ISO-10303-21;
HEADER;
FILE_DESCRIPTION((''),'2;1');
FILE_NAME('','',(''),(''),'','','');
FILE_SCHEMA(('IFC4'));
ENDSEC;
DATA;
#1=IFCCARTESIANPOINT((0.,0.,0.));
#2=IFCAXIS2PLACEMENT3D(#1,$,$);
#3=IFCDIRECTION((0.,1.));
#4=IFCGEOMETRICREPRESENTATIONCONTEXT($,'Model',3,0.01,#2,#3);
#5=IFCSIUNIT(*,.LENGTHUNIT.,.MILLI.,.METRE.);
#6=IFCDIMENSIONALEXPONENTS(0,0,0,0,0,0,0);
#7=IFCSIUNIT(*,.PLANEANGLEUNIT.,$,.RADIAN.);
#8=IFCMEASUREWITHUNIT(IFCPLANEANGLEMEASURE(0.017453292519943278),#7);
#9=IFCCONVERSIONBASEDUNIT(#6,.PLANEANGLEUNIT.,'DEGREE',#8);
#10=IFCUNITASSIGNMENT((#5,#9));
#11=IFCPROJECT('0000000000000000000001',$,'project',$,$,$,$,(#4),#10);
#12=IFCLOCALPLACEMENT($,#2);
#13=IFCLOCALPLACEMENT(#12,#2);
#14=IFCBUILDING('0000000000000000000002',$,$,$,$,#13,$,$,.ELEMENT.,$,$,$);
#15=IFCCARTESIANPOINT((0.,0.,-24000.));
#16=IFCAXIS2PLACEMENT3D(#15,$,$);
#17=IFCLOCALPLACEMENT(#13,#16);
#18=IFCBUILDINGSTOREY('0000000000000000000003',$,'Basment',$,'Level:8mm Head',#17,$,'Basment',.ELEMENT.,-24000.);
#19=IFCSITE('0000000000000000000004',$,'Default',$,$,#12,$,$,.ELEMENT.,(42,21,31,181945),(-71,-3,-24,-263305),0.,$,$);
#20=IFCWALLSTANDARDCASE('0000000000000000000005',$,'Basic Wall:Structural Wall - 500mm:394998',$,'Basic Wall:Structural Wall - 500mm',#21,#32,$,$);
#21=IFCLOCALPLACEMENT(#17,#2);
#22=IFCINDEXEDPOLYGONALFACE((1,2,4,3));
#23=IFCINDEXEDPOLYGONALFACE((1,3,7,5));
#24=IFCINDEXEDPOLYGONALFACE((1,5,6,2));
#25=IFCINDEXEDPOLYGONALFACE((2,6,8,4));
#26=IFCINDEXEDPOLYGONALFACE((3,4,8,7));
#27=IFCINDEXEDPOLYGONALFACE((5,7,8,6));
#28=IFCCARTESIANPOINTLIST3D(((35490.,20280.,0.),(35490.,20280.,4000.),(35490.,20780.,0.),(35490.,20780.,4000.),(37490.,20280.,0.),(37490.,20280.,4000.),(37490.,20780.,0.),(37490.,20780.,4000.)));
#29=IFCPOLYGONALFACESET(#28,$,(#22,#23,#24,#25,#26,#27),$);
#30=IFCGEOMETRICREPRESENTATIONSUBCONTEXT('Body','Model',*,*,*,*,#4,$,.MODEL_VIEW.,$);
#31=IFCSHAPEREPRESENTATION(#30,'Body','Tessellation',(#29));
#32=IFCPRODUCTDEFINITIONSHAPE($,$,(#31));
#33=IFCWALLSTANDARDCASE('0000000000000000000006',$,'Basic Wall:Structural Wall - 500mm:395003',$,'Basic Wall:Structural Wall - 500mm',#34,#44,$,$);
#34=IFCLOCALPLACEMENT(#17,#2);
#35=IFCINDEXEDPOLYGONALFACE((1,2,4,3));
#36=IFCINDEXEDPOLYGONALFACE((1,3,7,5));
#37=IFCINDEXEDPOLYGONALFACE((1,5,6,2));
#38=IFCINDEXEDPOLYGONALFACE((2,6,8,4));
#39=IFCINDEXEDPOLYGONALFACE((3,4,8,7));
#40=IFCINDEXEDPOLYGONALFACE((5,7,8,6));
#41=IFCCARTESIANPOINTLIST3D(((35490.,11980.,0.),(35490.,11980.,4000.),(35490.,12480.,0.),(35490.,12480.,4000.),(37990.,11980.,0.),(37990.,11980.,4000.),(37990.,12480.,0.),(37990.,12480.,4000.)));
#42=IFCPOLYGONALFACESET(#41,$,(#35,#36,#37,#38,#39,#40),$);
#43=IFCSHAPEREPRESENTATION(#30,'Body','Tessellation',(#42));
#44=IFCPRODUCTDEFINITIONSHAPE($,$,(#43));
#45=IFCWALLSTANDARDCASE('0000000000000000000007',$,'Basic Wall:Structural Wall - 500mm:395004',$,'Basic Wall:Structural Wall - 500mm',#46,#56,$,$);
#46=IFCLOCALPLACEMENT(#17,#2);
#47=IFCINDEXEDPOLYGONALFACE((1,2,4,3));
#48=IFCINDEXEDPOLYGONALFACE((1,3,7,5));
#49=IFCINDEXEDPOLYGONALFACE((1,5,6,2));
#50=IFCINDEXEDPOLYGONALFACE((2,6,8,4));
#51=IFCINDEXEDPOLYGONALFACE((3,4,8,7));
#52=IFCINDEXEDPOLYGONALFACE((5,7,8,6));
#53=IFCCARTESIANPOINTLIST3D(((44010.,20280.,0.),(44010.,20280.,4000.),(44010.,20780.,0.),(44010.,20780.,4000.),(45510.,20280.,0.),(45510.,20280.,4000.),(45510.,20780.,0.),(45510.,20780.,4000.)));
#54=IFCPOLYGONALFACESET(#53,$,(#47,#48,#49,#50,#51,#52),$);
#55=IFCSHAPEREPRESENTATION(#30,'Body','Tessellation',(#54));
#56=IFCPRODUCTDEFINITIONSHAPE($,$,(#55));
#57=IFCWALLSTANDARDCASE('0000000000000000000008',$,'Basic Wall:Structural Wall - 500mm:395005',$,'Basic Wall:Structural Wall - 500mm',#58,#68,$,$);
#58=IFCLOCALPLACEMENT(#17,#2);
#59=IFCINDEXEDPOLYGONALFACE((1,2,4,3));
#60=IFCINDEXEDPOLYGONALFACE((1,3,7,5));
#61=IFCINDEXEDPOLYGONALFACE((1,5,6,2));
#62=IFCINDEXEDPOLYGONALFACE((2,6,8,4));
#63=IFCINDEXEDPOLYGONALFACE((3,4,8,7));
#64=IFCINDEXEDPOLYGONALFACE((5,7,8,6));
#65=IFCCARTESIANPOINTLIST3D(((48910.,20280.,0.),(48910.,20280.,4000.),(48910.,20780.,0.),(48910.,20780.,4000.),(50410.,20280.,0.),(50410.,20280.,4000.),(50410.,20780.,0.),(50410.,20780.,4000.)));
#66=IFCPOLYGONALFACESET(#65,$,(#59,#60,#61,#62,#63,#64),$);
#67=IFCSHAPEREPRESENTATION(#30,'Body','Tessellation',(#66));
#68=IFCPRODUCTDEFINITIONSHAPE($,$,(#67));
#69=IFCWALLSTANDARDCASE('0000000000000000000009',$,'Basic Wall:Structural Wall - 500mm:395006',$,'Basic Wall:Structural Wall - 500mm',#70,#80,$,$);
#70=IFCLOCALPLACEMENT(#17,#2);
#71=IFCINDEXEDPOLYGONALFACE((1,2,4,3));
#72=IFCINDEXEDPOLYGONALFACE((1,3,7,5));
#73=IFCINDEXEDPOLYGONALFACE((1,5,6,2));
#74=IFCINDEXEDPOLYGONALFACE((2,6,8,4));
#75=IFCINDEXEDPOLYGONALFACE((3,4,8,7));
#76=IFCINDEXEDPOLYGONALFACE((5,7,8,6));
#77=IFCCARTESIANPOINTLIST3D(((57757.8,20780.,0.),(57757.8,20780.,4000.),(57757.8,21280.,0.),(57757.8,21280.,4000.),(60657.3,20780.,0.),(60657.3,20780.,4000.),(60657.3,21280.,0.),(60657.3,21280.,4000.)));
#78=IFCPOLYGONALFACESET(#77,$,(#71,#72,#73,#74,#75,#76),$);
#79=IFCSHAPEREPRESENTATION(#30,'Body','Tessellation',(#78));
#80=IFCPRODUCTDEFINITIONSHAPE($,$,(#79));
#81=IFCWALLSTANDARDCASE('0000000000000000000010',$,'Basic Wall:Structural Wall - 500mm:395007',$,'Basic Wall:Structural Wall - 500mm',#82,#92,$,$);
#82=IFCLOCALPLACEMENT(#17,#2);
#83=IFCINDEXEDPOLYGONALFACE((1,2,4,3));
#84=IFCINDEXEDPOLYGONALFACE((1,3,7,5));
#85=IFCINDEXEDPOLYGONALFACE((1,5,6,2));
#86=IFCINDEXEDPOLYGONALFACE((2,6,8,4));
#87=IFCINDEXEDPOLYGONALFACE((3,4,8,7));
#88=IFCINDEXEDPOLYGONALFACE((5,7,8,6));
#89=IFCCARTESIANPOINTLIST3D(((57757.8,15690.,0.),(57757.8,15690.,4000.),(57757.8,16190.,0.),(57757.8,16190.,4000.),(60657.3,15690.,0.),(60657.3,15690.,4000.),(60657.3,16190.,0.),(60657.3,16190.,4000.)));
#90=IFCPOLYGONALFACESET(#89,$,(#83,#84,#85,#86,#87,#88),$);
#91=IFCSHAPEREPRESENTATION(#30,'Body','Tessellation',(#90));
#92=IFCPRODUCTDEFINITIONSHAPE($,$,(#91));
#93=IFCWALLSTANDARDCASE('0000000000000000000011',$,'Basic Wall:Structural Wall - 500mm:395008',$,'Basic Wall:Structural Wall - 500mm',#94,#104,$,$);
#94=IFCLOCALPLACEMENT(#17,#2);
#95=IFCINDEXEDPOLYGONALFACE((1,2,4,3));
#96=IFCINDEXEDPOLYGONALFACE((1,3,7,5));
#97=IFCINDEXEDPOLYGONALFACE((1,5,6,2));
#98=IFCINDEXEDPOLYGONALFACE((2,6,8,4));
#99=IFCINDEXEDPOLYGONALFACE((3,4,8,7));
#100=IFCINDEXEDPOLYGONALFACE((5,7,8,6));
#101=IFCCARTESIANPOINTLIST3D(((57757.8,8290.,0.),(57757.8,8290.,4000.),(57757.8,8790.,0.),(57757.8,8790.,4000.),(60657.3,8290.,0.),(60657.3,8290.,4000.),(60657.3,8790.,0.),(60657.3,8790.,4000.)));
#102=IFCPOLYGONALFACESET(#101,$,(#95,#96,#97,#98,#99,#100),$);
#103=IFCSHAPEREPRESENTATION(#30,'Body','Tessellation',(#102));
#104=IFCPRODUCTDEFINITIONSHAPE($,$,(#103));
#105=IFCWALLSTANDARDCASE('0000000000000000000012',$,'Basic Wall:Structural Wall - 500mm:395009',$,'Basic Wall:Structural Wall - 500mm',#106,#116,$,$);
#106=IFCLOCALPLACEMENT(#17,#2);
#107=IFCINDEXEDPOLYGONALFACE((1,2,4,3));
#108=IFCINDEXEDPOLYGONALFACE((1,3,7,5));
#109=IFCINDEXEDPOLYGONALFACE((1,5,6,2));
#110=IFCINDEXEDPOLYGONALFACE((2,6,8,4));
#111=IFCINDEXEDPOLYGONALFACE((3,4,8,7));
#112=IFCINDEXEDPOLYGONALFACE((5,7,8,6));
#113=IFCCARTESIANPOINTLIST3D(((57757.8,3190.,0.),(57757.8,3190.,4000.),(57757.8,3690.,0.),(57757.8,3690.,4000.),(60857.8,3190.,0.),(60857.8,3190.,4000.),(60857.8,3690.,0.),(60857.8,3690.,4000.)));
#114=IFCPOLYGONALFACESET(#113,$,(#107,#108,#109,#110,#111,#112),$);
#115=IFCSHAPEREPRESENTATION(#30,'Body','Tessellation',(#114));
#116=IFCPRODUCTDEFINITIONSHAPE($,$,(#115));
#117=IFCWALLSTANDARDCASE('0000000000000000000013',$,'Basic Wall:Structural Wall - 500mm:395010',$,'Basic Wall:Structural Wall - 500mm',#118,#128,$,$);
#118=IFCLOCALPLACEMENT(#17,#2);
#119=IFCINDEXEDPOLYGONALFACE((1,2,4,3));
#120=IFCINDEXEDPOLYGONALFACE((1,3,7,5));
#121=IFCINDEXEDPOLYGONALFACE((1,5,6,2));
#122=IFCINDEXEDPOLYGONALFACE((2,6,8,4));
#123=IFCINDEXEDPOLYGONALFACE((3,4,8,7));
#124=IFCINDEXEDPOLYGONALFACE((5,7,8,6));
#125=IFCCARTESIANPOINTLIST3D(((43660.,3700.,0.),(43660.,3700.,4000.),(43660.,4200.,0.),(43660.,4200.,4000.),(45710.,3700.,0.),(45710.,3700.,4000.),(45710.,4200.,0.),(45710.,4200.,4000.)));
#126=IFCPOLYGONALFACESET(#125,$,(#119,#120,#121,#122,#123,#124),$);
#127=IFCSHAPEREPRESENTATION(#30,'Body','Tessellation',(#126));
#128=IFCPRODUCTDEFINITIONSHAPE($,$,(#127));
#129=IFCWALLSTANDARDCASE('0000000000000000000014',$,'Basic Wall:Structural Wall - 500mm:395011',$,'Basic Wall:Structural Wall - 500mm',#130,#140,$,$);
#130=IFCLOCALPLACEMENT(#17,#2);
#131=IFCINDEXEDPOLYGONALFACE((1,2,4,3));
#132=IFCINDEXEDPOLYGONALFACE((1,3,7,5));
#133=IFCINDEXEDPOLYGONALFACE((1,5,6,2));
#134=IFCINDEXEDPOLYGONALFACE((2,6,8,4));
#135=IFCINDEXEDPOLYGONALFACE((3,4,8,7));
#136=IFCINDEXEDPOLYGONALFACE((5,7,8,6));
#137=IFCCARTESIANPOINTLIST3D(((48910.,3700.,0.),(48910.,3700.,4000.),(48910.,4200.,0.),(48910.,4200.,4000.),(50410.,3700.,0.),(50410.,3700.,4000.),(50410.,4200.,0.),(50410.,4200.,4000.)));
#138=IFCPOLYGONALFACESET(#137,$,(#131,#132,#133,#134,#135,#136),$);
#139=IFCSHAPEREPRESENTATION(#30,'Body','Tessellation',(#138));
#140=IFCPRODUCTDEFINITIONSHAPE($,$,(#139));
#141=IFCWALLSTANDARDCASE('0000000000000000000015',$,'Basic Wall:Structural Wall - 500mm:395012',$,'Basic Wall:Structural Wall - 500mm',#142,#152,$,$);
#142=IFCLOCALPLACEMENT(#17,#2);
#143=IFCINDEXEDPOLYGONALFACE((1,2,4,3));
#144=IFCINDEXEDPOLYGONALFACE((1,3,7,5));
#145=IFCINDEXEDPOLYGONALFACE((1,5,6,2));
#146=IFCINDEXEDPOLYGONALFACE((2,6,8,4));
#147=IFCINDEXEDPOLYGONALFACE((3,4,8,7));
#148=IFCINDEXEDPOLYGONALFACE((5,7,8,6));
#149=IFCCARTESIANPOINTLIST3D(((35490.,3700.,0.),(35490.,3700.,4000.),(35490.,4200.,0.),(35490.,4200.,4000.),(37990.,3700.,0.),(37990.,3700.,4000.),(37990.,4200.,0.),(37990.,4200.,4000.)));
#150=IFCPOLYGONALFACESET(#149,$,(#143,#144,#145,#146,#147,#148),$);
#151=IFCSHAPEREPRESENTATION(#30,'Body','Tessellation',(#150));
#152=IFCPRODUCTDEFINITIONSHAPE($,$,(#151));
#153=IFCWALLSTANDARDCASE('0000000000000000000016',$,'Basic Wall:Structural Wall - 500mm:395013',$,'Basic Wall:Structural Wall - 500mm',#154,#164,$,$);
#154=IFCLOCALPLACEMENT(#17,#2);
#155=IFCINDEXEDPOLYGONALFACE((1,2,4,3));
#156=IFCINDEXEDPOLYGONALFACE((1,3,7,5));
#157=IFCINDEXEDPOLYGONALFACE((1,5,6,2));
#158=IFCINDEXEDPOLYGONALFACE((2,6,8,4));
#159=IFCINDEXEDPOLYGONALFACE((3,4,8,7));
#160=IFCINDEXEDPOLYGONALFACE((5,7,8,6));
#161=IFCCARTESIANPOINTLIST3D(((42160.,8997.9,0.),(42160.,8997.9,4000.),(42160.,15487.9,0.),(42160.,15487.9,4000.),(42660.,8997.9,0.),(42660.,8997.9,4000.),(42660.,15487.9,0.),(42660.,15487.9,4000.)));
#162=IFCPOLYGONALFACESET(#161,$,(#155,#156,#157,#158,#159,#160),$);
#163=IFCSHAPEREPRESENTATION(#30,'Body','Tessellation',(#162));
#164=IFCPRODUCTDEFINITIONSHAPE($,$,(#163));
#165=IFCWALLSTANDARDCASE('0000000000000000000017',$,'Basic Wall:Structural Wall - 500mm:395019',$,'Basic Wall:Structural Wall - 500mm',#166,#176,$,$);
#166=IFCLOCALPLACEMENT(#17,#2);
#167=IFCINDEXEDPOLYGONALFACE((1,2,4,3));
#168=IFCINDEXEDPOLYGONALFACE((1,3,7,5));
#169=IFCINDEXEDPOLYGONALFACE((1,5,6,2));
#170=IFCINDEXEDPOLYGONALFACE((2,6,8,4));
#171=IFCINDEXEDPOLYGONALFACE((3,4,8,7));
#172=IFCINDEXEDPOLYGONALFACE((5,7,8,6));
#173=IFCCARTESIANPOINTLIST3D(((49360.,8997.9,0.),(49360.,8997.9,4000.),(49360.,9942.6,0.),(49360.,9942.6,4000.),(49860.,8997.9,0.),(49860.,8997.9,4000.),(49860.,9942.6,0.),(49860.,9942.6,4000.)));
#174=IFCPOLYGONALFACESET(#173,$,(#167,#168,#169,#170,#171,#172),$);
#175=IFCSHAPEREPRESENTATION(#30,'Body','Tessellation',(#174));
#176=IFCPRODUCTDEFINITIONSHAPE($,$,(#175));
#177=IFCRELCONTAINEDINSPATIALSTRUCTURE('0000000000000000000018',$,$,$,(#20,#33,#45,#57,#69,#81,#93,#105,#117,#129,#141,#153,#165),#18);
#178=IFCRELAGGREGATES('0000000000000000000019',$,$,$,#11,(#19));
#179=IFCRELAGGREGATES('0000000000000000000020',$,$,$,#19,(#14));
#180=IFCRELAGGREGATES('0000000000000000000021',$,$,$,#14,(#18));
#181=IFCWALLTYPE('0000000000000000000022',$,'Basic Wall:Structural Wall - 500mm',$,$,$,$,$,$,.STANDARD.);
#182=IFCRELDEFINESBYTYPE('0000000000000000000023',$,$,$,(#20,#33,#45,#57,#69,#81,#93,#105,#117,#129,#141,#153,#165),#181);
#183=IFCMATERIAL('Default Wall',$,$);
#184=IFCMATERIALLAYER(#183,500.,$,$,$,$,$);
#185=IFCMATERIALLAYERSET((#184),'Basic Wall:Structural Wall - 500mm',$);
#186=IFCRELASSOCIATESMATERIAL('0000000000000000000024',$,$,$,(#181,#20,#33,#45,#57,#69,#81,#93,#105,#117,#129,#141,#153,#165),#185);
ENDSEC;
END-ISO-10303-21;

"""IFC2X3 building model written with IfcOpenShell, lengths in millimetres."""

from ifc_helpers import new_model, entity, si_unit, converted_unit, direction, frame, frame_2d, origin, place, context, subcontext, project, spatial, rectangle, extrude, material, layer, layer_set, layer_usage, type_object, element, save


model = new_model("IFC2X3")

# Units and contexts
model_context = context("Model", 3, precision=0.01, world=origin(), true_north=direction((0.0, 1.0)))
body_context = subcontext(model_context, "Body", "Model", "MODEL_VIEW")
ifc_project = project(units=[si_unit("LENGTHUNIT", "METRE", prefix="MILLI"), converted_unit("PLANEANGLEUNIT", "DEGREE", entity("IfcPlaneAngleMeasure", 0.017453292519943278), si_unit("PLANEANGLEUNIT", "RADIAN"), dimensions=[0, 0, 0, 0, 0, 0, 0])], contexts=[model_context])

# Site, building, storey
site_placement = place(None, origin())
site = spatial("IfcSite", under=ifc_project, at=site_placement, Name="Default", CompositionType="ELEMENT", RefLatitude=(42, 21, 31, 181945), RefLongitude=(-71, -3, -24, -263305), RefElevation=0.0)
building_placement = place(site_placement, origin())
building = spatial("IfcBuilding", under=site, at=building_placement, CompositionType="ELEMENT")
storey_placement = place(building_placement, frame((0.0, 0.0, -24000.0)))
storey = spatial("IfcBuildingStorey", under=building, at=storey_placement, Name="Basment", ObjectType="Level:8mm Head", LongName="Basment", CompositionType="ELEMENT", Elevation=-24000.0)

# Walls
ifc_material_1 = material(Name="Default Wall")
ifc_layer_1 = layer(ifc_material_1, 500.0)
ifc_layer_set_1 = layer_set([ifc_layer_1], Name="Basic Wall:Structural Wall - 500mm")
ifc_layer_usage_1 = layer_usage(ifc_layer_set_1, "AXIS2", "NEGATIVE", 250.0)
wall_type_1 = type_object("IfcWallType", Name="Basic Wall:Structural Wall - 500mm", PredefinedType="STANDARD", material=ifc_layer_set_1)
wall_1_placement = place(storey_placement, frame((35490.0, 20530.0, 0.0)))
element("IfcWallStandardCase", 1, at=wall_1_placement, inside=storey, type_object=wall_type_1, material=ifc_layer_usage_1, Name="Basic Wall:Structural Wall - 500mm:394998", ObjectType="Basic Wall:Structural Wall - 500mm", context=body_context, shape_type="SweptSolid", body=[
    extrude(rectangle(XDim=2000.0, YDim=500.0, at=frame_2d((1000.0, 0.0), x_axis=(-1.0, 0.0))), origin(), (0.0, 0.0, 1.0), 4000.0),
])
ifc_layer_usage_2 = layer_usage(ifc_layer_set_1, "AXIS2", "NEGATIVE", 250.0)
wall_2_placement = place(storey_placement, frame((35490.0, 12230.0, 0.0)))
element("IfcWallStandardCase", 2, at=wall_2_placement, inside=storey, type_object=wall_type_1, material=ifc_layer_usage_2, Name="Basic Wall:Structural Wall - 500mm:395003", ObjectType="Basic Wall:Structural Wall - 500mm", context=body_context, shape_type="SweptSolid", body=[
    extrude(rectangle(XDim=2500.0, YDim=500.0, at=frame_2d((1250.0, 0.0), x_axis=(-1.0, 0.0))), origin(), (0.0, 0.0, 1.0), 4000.0),
])
ifc_layer_usage_3 = layer_usage(ifc_layer_set_1, "AXIS2", "NEGATIVE", 250.0)
wall_3_placement = place(storey_placement, frame((44010.0, 20530.0, 0.0)))
element("IfcWallStandardCase", 3, at=wall_3_placement, inside=storey, type_object=wall_type_1, material=ifc_layer_usage_3, Name="Basic Wall:Structural Wall - 500mm:395004", ObjectType="Basic Wall:Structural Wall - 500mm", context=body_context, shape_type="SweptSolid", body=[
    extrude(rectangle(XDim=1500.0, YDim=500.0, at=frame_2d((750.0, 0.0), x_axis=(-1.0, 0.0))), origin(), (0.0, 0.0, 1.0), 4000.0),
])
ifc_layer_usage_4 = layer_usage(ifc_layer_set_1, "AXIS2", "NEGATIVE", 250.0)
wall_4_placement = place(storey_placement, frame((48910.0, 20530.0, 0.0)))
element("IfcWallStandardCase", 4, at=wall_4_placement, inside=storey, type_object=wall_type_1, material=ifc_layer_usage_4, Name="Basic Wall:Structural Wall - 500mm:395005", ObjectType="Basic Wall:Structural Wall - 500mm", context=body_context, shape_type="SweptSolid", body=[
    extrude(rectangle(XDim=1500.0, YDim=500.0, at=frame_2d((750.0, 0.0), x_axis=(-1.0, 0.0))), origin(), (0.0, 0.0, 1.0), 4000.0),
])
ifc_layer_usage_5 = layer_usage(ifc_layer_set_1, "AXIS2", "NEGATIVE", 250.0)
wall_5_placement = place(storey_placement, frame((57757.8, 21030.0, 0.0)))
element("IfcWallStandardCase", 5, at=wall_5_placement, inside=storey, type_object=wall_type_1, material=ifc_layer_usage_5, Name="Basic Wall:Structural Wall - 500mm:395006", ObjectType="Basic Wall:Structural Wall - 500mm", context=body_context, shape_type="SweptSolid", body=[
    extrude(rectangle(XDim=2899.5, YDim=500.0, at=frame_2d((1449.8, 0.0), x_axis=(-1.0, 0.0))), origin(), (0.0, 0.0, 1.0), 4000.0),
])
ifc_layer_usage_6 = layer_usage(ifc_layer_set_1, "AXIS2", "NEGATIVE", 250.0)
wall_6_placement = place(storey_placement, frame((57757.8, 15940.0, 0.0)))
element("IfcWallStandardCase", 6, at=wall_6_placement, inside=storey, type_object=wall_type_1, material=ifc_layer_usage_6, Name="Basic Wall:Structural Wall - 500mm:395007", ObjectType="Basic Wall:Structural Wall - 500mm", context=body_context, shape_type="SweptSolid", body=[
    extrude(rectangle(XDim=2899.5, YDim=500.0, at=frame_2d((1449.8, 0.0), x_axis=(-1.0, 0.0))), origin(), (0.0, 0.0, 1.0), 4000.0),
])
ifc_layer_usage_7 = layer_usage(ifc_layer_set_1, "AXIS2", "NEGATIVE", 250.0)
wall_7_placement = place(storey_placement, frame((57757.8, 8540.0, 0.0)))
element("IfcWallStandardCase", 7, at=wall_7_placement, inside=storey, type_object=wall_type_1, material=ifc_layer_usage_7, Name="Basic Wall:Structural Wall - 500mm:395008", ObjectType="Basic Wall:Structural Wall - 500mm", context=body_context, shape_type="SweptSolid", body=[
    extrude(rectangle(XDim=2899.5, YDim=500.0, at=frame_2d((1449.8, 0.0), x_axis=(-1.0, 0.0))), origin(), (0.0, 0.0, 1.0), 4000.0),
])
ifc_layer_usage_8 = layer_usage(ifc_layer_set_1, "AXIS2", "NEGATIVE", 250.0)
wall_8_placement = place(storey_placement, frame((57757.8, 3440.0, 0.0)))
element("IfcWallStandardCase", 8, at=wall_8_placement, inside=storey, type_object=wall_type_1, material=ifc_layer_usage_8, Name="Basic Wall:Structural Wall - 500mm:395009", ObjectType="Basic Wall:Structural Wall - 500mm", context=body_context, shape_type="SweptSolid", body=[
    extrude(rectangle(XDim=3100.0, YDim=500.0, at=frame_2d((1550.0, 0.0), x_axis=(-1.0, 0.0))), origin(), (0.0, 0.0, 1.0), 4000.0),
])
ifc_layer_usage_9 = layer_usage(ifc_layer_set_1, "AXIS2", "NEGATIVE", 250.0)
wall_9_placement = place(storey_placement, frame((43660.0, 3950.0, 0.0)))
element("IfcWallStandardCase", 9, at=wall_9_placement, inside=storey, type_object=wall_type_1, material=ifc_layer_usage_9, Name="Basic Wall:Structural Wall - 500mm:395010", ObjectType="Basic Wall:Structural Wall - 500mm", context=body_context, shape_type="SweptSolid", body=[
    extrude(rectangle(XDim=2050.0, YDim=500.0, at=frame_2d((1025.0, 0.0), x_axis=(-1.0, 0.0))), origin(), (0.0, 0.0, 1.0), 4000.0),
])
ifc_layer_usage_10 = layer_usage(ifc_layer_set_1, "AXIS2", "NEGATIVE", 250.0)
wall_10_placement = place(storey_placement, frame((48910.0, 3950.0, 0.0)))
element("IfcWallStandardCase", 10, at=wall_10_placement, inside=storey, type_object=wall_type_1, material=ifc_layer_usage_10, Name="Basic Wall:Structural Wall - 500mm:395011", ObjectType="Basic Wall:Structural Wall - 500mm", context=body_context, shape_type="SweptSolid", body=[
    extrude(rectangle(XDim=1500.0, YDim=500.0, at=frame_2d((750.0, 0.0), x_axis=(-1.0, 0.0))), origin(), (0.0, 0.0, 1.0), 4000.0),
])
ifc_layer_usage_11 = layer_usage(ifc_layer_set_1, "AXIS2", "NEGATIVE", 250.0)
wall_11_placement = place(storey_placement, frame((35490.0, 3950.0, 0.0)))
element("IfcWallStandardCase", 11, at=wall_11_placement, inside=storey, type_object=wall_type_1, material=ifc_layer_usage_11, Name="Basic Wall:Structural Wall - 500mm:395012", ObjectType="Basic Wall:Structural Wall - 500mm", context=body_context, shape_type="SweptSolid", body=[
    extrude(rectangle(XDim=2500.0, YDim=500.0, at=frame_2d((1250.0, 0.0), x_axis=(-1.0, 0.0))), origin(), (0.0, 0.0, 1.0), 4000.0),
])
ifc_layer_usage_12 = layer_usage(ifc_layer_set_1, "AXIS2", "NEGATIVE", 250.0)
wall_12_placement = place(storey_placement, frame((42410.0, 15487.9, 0.0), z_axis=(0.0, 0.0, 1.0), x_axis=(0.0, -1.0, 0.0)))
element("IfcWallStandardCase", 12, at=wall_12_placement, inside=storey, type_object=wall_type_1, material=ifc_layer_usage_12, Name="Basic Wall:Structural Wall - 500mm:395013", ObjectType="Basic Wall:Structural Wall - 500mm", context=body_context, shape_type="SweptSolid", body=[
    extrude(rectangle(XDim=6490.0, YDim=500.0, at=frame_2d((3245.0, 0.0), x_axis=(-1.0, 0.0))), origin(), (0.0, 0.0, 1.0), 4000.0),
])
ifc_layer_usage_13 = layer_usage(ifc_layer_set_1, "AXIS2", "NEGATIVE", 250.0)
wall_13_placement = place(storey_placement, frame((49610.0, 8997.9, 0.0), z_axis=(0.0, 0.0, 1.0), x_axis=(0.0, 1.0, 0.0)))
element("IfcWallStandardCase", 13, at=wall_13_placement, inside=storey, type_object=wall_type_1, material=ifc_layer_usage_13, Name="Basic Wall:Structural Wall - 500mm:395019", ObjectType="Basic Wall:Structural Wall - 500mm", context=body_context, shape_type="SweptSolid", body=[
    extrude(rectangle(XDim=944.7, YDim=500.0, at=frame_2d((472.3, 0.0), x_axis=(-1.0, 0.0))), origin(), (0.0, 0.0, 1.0), 4000.0),
])

save(model, "model.ifc")
